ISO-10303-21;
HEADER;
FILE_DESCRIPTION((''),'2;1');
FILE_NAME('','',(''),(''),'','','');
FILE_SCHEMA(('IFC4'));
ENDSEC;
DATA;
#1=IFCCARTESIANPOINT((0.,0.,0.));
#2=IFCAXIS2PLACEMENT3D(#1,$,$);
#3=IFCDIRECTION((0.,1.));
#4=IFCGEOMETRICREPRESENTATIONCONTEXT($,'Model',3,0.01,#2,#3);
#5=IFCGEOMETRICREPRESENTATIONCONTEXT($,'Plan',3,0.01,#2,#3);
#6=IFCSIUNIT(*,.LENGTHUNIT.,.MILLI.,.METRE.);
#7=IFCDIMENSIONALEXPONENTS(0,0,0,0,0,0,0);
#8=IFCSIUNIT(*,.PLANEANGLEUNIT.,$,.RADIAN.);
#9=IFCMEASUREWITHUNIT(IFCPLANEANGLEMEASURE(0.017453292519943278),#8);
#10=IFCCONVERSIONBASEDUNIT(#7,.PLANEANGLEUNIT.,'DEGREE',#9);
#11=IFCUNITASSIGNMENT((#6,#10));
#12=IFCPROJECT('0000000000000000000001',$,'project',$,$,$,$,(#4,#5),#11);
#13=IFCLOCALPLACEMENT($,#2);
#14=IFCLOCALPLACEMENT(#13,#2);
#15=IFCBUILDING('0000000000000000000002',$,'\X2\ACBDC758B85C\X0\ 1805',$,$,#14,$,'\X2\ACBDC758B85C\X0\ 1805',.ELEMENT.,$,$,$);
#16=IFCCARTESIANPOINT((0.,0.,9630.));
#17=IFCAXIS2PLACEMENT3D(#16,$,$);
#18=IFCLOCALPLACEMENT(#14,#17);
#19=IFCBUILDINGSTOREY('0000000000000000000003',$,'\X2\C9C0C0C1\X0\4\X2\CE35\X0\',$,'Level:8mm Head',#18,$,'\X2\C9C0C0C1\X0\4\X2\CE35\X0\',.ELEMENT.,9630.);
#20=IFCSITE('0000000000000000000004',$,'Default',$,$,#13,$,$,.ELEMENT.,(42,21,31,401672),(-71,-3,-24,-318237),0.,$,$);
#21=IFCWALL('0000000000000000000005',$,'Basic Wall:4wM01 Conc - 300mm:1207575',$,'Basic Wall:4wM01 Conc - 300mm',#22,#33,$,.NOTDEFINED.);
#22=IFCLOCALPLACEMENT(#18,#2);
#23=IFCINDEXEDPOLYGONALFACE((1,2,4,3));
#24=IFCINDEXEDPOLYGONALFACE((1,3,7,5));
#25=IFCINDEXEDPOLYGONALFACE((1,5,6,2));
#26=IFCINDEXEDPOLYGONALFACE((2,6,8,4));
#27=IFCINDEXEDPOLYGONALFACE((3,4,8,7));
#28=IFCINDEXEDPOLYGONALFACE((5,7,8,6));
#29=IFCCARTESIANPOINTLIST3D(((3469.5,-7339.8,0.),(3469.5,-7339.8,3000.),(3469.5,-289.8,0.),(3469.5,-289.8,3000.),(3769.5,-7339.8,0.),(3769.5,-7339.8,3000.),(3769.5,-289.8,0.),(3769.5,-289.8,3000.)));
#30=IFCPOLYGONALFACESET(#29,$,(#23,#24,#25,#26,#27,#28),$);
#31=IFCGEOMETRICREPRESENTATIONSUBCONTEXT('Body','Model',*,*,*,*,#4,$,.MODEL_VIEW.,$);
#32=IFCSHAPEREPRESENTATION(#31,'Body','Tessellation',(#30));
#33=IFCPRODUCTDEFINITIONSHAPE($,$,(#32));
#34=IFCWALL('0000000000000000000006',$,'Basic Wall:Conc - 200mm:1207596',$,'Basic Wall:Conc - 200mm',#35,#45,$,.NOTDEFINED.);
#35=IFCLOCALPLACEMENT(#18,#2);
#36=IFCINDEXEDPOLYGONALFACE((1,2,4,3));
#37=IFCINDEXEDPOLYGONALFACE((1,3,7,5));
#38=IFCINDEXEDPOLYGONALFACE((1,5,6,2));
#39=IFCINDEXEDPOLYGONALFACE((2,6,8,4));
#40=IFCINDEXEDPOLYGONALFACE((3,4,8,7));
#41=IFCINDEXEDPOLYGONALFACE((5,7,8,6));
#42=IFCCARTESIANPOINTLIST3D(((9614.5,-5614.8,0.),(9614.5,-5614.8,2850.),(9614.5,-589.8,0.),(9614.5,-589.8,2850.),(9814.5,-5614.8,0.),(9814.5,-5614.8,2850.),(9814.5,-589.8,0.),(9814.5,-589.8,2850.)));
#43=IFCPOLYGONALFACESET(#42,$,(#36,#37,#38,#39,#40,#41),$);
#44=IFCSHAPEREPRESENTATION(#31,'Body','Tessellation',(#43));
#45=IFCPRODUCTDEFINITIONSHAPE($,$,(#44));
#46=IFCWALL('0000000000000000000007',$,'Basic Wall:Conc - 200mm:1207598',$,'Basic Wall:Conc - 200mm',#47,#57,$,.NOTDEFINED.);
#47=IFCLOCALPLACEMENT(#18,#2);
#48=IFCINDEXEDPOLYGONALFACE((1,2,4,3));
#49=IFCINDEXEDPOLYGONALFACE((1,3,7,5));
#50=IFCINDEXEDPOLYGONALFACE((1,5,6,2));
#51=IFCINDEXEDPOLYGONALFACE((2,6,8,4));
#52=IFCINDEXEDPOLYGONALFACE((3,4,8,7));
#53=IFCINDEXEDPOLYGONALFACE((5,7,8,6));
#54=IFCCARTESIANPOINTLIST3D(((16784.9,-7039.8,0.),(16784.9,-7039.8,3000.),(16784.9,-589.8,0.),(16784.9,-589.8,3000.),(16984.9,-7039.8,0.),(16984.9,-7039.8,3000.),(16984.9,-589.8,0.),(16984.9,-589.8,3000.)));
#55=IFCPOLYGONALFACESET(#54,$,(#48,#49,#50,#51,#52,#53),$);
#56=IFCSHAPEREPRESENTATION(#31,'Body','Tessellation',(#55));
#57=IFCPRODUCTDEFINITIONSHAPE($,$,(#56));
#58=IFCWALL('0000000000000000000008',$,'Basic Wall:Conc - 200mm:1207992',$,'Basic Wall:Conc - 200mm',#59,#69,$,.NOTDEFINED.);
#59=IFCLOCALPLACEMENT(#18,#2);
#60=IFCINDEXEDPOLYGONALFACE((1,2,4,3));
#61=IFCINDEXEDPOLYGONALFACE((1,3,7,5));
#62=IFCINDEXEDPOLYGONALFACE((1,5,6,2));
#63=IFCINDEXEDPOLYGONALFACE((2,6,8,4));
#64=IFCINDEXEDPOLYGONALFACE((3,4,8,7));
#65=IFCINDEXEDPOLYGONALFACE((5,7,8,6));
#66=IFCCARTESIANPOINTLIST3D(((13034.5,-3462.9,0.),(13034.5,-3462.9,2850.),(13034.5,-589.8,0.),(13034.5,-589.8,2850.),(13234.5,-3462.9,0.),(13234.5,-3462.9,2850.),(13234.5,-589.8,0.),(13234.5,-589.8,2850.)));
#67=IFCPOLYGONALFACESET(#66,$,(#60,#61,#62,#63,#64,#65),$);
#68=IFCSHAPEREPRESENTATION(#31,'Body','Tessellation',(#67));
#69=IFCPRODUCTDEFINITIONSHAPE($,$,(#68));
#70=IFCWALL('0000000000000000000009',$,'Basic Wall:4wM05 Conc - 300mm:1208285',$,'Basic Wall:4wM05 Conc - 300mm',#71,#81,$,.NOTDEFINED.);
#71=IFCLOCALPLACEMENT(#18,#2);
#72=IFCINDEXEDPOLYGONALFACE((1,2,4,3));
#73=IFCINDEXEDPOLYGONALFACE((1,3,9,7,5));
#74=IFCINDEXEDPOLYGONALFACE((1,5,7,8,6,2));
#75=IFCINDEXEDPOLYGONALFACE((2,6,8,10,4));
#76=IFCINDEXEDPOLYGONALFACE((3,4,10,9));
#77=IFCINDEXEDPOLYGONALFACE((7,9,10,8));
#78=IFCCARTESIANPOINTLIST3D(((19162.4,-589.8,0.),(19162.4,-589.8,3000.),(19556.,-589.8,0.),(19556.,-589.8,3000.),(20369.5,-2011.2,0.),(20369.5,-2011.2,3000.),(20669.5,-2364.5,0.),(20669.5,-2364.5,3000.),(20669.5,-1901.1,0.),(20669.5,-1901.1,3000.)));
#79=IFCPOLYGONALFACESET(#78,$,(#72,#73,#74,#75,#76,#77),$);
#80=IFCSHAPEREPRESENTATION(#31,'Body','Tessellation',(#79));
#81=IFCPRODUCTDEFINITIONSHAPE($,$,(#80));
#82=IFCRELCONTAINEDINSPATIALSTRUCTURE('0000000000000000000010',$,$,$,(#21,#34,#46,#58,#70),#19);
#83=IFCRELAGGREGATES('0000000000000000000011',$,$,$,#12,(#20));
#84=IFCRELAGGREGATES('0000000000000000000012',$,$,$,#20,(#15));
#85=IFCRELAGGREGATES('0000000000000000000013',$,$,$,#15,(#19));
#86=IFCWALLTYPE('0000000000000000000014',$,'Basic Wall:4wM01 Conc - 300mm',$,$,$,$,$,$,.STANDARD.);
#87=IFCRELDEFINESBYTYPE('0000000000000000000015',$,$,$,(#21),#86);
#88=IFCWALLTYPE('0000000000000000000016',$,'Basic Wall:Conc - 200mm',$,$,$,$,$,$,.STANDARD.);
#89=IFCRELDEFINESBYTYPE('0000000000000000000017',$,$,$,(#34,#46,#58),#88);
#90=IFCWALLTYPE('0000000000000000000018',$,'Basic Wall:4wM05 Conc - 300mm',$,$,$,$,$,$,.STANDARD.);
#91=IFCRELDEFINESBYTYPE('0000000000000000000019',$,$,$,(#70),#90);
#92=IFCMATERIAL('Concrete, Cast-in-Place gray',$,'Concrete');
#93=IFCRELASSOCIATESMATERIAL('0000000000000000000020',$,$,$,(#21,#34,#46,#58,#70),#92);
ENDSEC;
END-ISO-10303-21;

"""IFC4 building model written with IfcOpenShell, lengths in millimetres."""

from ifc_helpers import new_model, entity, si_unit, converted_unit, direction, frame, origin, place, context, subcontext, project, spatial, indexed_curve, outline, extrude, material, type_object, element, save


model = new_model("IFC4")

# Units and contexts
model_context = context("Model", 3, precision=0.01, world=origin(), true_north=direction((0.0, 1.0)))
plan_context = context("Plan", 3, precision=0.01, world=origin(), true_north=direction((0.0, 1.0)))
body_context = subcontext(model_context, "Body", "Model", "MODEL_VIEW")
ifc_project = project(units=[si_unit("LENGTHUNIT", "METRE", prefix="MILLI"), converted_unit("PLANEANGLEUNIT", "DEGREE", entity("IfcPlaneAngleMeasure", 0.017453292519943278), si_unit("PLANEANGLEUNIT", "RADIAN"), dimensions=[0, 0, 0, 0, 0, 0, 0])], contexts=[model_context, plan_context])

# Site, building, storey
site_placement = place(None, origin())
site = spatial("IfcSite", under=ifc_project, at=site_placement, Name="Default", CompositionType="ELEMENT", RefLatitude=(42, 21, 31, 401672), RefLongitude=(-71, -3, -24, -318237), RefElevation=0.0)
building_placement = place(site_placement, origin())
building = spatial("IfcBuilding", under=site, at=building_placement, Name="경의로 1805", LongName="경의로 1805", CompositionType="ELEMENT")
storey_placement = place(building_placement, frame((0.0, 0.0, 9630.0)))
storey = spatial("IfcBuildingStorey", under=building, at=storey_placement, Name="지상4층", ObjectType="Level:8mm Head", LongName="지상4층", CompositionType="ELEMENT", Elevation=9630.0)

# Walls
ifc_material_1 = material(Name="Concrete, Cast-in-Place gray", Category="Concrete")
wall_type_1 = type_object("IfcWallType", Name="Basic Wall:4wM01 Conc - 300mm", PredefinedType="STANDARD")
wall_1_placement = place(storey_placement, frame((3619.5, -7339.8, 0.0), z_axis=(0.0, 0.0, 1.0), x_axis=(0.0, 1.0, 0.0)))
element("IfcWall", 1, at=wall_1_placement, inside=storey, type_object=wall_type_1, material=ifc_material_1, Name="Basic Wall:4wM01 Conc - 300mm:1207575", ObjectType="Basic Wall:4wM01 Conc - 300mm", PredefinedType="NOTDEFINED", context=body_context, shape_type="SweptSolid", body=[
    extrude(outline(indexed_curve([(7050.0, 150.0), (0.0, 150.0), (0.0, -150.0), (7050.0, -150.0), (7050.0, 150.0)], self_intersect=False)), origin(), (0.0, 0.0, 1.0), 3000.0),
])
wall_type_2 = type_object("IfcWallType", Name="Basic Wall:Conc - 200mm", PredefinedType="STANDARD")
wall_2_placement = place(storey_placement, frame((9714.5, -589.8, 0.0), z_axis=(0.0, 0.0, 1.0), x_axis=(0.0, -1.0, 0.0)))
element("IfcWall", 2, at=wall_2_placement, inside=storey, type_object=wall_type_2, material=ifc_material_1, Name="Basic Wall:Conc - 200mm:1207596", ObjectType="Basic Wall:Conc - 200mm", PredefinedType="NOTDEFINED", context=body_context, shape_type="SweptSolid", body=[
    extrude(outline(indexed_curve([(5025.0, 100.0), (0.0, 100.0), (0.0, -100.0), (5025.0, -100.0), (5025.0, 100.0)], self_intersect=False)), origin(), (0.0, 0.0, 1.0), 2850.0),
])
wall_3_placement = place(storey_placement, frame((16884.9, -589.8, 0.0), z_axis=(0.0, 0.0, 1.0), x_axis=(0.0, -1.0, 0.0)))
element("IfcWall", 3, at=wall_3_placement, inside=storey, type_object=wall_type_2, material=ifc_material_1, Name="Basic Wall:Conc - 200mm:1207598", ObjectType="Basic Wall:Conc - 200mm", PredefinedType="NOTDEFINED", context=body_context, shape_type="SweptSolid", body=[
    extrude(outline(indexed_curve([(6450.0, 100.0), (0.0, 100.0), (0.0, -100.0), (6450.0, -100.0), (6450.0, 100.0)], self_intersect=False)), origin(), (0.0, 0.0, 1.0), 3000.0),
])
wall_4_placement = place(storey_placement, frame((13134.5, -589.8, 0.0), z_axis=(0.0, 0.0, 1.0), x_axis=(0.0, -1.0, 0.0)))
element("IfcWall", 4, at=wall_4_placement, inside=storey, type_object=wall_type_2, material=ifc_material_1, Name="Basic Wall:Conc - 200mm:1207992", ObjectType="Basic Wall:Conc - 200mm", PredefinedType="NOTDEFINED", context=body_context, shape_type="SweptSolid", body=[
    extrude(outline(indexed_curve([(2873.0, 100.0), (0.0, 100.0), (0.0, -100.0), (2873.0, -100.0), (2873.0, 100.0)], self_intersect=False)), origin(), (0.0, 0.0, 1.0), 2850.0),
])
wall_type_3 = type_object("IfcWallType", Name="Basic Wall:4wM05 Conc - 300mm", PredefinedType="STANDARD")
wall_5_placement = place(storey_placement, frame((19276.8, -492.7, 0.0), z_axis=(0.0, 0.0, 1.0), x_axis=(0.647298, -0.762237, 0.0)))
element("IfcWall", 5, at=wall_5_placement, inside=storey, type_object=wall_type_3, material=ifc_material_1, Name="Basic Wall:4wM05 Conc - 300mm:1208285", ObjectType="Basic Wall:4wM05 Conc - 300mm", PredefinedType="NOTDEFINED", context=body_context, shape_type="SweptSolid", body=[
    extrude(outline(indexed_curve([(2328.3, -150.0), (1975.0, 150.0), (254.8, 150.0), (0.0, -150.0), (1864.8, -150.0), (2328.3, -150.0)], self_intersect=False)), origin(), (0.0, 0.0, 1.0), 3000.0),
])

save(model, "model.ifc")
